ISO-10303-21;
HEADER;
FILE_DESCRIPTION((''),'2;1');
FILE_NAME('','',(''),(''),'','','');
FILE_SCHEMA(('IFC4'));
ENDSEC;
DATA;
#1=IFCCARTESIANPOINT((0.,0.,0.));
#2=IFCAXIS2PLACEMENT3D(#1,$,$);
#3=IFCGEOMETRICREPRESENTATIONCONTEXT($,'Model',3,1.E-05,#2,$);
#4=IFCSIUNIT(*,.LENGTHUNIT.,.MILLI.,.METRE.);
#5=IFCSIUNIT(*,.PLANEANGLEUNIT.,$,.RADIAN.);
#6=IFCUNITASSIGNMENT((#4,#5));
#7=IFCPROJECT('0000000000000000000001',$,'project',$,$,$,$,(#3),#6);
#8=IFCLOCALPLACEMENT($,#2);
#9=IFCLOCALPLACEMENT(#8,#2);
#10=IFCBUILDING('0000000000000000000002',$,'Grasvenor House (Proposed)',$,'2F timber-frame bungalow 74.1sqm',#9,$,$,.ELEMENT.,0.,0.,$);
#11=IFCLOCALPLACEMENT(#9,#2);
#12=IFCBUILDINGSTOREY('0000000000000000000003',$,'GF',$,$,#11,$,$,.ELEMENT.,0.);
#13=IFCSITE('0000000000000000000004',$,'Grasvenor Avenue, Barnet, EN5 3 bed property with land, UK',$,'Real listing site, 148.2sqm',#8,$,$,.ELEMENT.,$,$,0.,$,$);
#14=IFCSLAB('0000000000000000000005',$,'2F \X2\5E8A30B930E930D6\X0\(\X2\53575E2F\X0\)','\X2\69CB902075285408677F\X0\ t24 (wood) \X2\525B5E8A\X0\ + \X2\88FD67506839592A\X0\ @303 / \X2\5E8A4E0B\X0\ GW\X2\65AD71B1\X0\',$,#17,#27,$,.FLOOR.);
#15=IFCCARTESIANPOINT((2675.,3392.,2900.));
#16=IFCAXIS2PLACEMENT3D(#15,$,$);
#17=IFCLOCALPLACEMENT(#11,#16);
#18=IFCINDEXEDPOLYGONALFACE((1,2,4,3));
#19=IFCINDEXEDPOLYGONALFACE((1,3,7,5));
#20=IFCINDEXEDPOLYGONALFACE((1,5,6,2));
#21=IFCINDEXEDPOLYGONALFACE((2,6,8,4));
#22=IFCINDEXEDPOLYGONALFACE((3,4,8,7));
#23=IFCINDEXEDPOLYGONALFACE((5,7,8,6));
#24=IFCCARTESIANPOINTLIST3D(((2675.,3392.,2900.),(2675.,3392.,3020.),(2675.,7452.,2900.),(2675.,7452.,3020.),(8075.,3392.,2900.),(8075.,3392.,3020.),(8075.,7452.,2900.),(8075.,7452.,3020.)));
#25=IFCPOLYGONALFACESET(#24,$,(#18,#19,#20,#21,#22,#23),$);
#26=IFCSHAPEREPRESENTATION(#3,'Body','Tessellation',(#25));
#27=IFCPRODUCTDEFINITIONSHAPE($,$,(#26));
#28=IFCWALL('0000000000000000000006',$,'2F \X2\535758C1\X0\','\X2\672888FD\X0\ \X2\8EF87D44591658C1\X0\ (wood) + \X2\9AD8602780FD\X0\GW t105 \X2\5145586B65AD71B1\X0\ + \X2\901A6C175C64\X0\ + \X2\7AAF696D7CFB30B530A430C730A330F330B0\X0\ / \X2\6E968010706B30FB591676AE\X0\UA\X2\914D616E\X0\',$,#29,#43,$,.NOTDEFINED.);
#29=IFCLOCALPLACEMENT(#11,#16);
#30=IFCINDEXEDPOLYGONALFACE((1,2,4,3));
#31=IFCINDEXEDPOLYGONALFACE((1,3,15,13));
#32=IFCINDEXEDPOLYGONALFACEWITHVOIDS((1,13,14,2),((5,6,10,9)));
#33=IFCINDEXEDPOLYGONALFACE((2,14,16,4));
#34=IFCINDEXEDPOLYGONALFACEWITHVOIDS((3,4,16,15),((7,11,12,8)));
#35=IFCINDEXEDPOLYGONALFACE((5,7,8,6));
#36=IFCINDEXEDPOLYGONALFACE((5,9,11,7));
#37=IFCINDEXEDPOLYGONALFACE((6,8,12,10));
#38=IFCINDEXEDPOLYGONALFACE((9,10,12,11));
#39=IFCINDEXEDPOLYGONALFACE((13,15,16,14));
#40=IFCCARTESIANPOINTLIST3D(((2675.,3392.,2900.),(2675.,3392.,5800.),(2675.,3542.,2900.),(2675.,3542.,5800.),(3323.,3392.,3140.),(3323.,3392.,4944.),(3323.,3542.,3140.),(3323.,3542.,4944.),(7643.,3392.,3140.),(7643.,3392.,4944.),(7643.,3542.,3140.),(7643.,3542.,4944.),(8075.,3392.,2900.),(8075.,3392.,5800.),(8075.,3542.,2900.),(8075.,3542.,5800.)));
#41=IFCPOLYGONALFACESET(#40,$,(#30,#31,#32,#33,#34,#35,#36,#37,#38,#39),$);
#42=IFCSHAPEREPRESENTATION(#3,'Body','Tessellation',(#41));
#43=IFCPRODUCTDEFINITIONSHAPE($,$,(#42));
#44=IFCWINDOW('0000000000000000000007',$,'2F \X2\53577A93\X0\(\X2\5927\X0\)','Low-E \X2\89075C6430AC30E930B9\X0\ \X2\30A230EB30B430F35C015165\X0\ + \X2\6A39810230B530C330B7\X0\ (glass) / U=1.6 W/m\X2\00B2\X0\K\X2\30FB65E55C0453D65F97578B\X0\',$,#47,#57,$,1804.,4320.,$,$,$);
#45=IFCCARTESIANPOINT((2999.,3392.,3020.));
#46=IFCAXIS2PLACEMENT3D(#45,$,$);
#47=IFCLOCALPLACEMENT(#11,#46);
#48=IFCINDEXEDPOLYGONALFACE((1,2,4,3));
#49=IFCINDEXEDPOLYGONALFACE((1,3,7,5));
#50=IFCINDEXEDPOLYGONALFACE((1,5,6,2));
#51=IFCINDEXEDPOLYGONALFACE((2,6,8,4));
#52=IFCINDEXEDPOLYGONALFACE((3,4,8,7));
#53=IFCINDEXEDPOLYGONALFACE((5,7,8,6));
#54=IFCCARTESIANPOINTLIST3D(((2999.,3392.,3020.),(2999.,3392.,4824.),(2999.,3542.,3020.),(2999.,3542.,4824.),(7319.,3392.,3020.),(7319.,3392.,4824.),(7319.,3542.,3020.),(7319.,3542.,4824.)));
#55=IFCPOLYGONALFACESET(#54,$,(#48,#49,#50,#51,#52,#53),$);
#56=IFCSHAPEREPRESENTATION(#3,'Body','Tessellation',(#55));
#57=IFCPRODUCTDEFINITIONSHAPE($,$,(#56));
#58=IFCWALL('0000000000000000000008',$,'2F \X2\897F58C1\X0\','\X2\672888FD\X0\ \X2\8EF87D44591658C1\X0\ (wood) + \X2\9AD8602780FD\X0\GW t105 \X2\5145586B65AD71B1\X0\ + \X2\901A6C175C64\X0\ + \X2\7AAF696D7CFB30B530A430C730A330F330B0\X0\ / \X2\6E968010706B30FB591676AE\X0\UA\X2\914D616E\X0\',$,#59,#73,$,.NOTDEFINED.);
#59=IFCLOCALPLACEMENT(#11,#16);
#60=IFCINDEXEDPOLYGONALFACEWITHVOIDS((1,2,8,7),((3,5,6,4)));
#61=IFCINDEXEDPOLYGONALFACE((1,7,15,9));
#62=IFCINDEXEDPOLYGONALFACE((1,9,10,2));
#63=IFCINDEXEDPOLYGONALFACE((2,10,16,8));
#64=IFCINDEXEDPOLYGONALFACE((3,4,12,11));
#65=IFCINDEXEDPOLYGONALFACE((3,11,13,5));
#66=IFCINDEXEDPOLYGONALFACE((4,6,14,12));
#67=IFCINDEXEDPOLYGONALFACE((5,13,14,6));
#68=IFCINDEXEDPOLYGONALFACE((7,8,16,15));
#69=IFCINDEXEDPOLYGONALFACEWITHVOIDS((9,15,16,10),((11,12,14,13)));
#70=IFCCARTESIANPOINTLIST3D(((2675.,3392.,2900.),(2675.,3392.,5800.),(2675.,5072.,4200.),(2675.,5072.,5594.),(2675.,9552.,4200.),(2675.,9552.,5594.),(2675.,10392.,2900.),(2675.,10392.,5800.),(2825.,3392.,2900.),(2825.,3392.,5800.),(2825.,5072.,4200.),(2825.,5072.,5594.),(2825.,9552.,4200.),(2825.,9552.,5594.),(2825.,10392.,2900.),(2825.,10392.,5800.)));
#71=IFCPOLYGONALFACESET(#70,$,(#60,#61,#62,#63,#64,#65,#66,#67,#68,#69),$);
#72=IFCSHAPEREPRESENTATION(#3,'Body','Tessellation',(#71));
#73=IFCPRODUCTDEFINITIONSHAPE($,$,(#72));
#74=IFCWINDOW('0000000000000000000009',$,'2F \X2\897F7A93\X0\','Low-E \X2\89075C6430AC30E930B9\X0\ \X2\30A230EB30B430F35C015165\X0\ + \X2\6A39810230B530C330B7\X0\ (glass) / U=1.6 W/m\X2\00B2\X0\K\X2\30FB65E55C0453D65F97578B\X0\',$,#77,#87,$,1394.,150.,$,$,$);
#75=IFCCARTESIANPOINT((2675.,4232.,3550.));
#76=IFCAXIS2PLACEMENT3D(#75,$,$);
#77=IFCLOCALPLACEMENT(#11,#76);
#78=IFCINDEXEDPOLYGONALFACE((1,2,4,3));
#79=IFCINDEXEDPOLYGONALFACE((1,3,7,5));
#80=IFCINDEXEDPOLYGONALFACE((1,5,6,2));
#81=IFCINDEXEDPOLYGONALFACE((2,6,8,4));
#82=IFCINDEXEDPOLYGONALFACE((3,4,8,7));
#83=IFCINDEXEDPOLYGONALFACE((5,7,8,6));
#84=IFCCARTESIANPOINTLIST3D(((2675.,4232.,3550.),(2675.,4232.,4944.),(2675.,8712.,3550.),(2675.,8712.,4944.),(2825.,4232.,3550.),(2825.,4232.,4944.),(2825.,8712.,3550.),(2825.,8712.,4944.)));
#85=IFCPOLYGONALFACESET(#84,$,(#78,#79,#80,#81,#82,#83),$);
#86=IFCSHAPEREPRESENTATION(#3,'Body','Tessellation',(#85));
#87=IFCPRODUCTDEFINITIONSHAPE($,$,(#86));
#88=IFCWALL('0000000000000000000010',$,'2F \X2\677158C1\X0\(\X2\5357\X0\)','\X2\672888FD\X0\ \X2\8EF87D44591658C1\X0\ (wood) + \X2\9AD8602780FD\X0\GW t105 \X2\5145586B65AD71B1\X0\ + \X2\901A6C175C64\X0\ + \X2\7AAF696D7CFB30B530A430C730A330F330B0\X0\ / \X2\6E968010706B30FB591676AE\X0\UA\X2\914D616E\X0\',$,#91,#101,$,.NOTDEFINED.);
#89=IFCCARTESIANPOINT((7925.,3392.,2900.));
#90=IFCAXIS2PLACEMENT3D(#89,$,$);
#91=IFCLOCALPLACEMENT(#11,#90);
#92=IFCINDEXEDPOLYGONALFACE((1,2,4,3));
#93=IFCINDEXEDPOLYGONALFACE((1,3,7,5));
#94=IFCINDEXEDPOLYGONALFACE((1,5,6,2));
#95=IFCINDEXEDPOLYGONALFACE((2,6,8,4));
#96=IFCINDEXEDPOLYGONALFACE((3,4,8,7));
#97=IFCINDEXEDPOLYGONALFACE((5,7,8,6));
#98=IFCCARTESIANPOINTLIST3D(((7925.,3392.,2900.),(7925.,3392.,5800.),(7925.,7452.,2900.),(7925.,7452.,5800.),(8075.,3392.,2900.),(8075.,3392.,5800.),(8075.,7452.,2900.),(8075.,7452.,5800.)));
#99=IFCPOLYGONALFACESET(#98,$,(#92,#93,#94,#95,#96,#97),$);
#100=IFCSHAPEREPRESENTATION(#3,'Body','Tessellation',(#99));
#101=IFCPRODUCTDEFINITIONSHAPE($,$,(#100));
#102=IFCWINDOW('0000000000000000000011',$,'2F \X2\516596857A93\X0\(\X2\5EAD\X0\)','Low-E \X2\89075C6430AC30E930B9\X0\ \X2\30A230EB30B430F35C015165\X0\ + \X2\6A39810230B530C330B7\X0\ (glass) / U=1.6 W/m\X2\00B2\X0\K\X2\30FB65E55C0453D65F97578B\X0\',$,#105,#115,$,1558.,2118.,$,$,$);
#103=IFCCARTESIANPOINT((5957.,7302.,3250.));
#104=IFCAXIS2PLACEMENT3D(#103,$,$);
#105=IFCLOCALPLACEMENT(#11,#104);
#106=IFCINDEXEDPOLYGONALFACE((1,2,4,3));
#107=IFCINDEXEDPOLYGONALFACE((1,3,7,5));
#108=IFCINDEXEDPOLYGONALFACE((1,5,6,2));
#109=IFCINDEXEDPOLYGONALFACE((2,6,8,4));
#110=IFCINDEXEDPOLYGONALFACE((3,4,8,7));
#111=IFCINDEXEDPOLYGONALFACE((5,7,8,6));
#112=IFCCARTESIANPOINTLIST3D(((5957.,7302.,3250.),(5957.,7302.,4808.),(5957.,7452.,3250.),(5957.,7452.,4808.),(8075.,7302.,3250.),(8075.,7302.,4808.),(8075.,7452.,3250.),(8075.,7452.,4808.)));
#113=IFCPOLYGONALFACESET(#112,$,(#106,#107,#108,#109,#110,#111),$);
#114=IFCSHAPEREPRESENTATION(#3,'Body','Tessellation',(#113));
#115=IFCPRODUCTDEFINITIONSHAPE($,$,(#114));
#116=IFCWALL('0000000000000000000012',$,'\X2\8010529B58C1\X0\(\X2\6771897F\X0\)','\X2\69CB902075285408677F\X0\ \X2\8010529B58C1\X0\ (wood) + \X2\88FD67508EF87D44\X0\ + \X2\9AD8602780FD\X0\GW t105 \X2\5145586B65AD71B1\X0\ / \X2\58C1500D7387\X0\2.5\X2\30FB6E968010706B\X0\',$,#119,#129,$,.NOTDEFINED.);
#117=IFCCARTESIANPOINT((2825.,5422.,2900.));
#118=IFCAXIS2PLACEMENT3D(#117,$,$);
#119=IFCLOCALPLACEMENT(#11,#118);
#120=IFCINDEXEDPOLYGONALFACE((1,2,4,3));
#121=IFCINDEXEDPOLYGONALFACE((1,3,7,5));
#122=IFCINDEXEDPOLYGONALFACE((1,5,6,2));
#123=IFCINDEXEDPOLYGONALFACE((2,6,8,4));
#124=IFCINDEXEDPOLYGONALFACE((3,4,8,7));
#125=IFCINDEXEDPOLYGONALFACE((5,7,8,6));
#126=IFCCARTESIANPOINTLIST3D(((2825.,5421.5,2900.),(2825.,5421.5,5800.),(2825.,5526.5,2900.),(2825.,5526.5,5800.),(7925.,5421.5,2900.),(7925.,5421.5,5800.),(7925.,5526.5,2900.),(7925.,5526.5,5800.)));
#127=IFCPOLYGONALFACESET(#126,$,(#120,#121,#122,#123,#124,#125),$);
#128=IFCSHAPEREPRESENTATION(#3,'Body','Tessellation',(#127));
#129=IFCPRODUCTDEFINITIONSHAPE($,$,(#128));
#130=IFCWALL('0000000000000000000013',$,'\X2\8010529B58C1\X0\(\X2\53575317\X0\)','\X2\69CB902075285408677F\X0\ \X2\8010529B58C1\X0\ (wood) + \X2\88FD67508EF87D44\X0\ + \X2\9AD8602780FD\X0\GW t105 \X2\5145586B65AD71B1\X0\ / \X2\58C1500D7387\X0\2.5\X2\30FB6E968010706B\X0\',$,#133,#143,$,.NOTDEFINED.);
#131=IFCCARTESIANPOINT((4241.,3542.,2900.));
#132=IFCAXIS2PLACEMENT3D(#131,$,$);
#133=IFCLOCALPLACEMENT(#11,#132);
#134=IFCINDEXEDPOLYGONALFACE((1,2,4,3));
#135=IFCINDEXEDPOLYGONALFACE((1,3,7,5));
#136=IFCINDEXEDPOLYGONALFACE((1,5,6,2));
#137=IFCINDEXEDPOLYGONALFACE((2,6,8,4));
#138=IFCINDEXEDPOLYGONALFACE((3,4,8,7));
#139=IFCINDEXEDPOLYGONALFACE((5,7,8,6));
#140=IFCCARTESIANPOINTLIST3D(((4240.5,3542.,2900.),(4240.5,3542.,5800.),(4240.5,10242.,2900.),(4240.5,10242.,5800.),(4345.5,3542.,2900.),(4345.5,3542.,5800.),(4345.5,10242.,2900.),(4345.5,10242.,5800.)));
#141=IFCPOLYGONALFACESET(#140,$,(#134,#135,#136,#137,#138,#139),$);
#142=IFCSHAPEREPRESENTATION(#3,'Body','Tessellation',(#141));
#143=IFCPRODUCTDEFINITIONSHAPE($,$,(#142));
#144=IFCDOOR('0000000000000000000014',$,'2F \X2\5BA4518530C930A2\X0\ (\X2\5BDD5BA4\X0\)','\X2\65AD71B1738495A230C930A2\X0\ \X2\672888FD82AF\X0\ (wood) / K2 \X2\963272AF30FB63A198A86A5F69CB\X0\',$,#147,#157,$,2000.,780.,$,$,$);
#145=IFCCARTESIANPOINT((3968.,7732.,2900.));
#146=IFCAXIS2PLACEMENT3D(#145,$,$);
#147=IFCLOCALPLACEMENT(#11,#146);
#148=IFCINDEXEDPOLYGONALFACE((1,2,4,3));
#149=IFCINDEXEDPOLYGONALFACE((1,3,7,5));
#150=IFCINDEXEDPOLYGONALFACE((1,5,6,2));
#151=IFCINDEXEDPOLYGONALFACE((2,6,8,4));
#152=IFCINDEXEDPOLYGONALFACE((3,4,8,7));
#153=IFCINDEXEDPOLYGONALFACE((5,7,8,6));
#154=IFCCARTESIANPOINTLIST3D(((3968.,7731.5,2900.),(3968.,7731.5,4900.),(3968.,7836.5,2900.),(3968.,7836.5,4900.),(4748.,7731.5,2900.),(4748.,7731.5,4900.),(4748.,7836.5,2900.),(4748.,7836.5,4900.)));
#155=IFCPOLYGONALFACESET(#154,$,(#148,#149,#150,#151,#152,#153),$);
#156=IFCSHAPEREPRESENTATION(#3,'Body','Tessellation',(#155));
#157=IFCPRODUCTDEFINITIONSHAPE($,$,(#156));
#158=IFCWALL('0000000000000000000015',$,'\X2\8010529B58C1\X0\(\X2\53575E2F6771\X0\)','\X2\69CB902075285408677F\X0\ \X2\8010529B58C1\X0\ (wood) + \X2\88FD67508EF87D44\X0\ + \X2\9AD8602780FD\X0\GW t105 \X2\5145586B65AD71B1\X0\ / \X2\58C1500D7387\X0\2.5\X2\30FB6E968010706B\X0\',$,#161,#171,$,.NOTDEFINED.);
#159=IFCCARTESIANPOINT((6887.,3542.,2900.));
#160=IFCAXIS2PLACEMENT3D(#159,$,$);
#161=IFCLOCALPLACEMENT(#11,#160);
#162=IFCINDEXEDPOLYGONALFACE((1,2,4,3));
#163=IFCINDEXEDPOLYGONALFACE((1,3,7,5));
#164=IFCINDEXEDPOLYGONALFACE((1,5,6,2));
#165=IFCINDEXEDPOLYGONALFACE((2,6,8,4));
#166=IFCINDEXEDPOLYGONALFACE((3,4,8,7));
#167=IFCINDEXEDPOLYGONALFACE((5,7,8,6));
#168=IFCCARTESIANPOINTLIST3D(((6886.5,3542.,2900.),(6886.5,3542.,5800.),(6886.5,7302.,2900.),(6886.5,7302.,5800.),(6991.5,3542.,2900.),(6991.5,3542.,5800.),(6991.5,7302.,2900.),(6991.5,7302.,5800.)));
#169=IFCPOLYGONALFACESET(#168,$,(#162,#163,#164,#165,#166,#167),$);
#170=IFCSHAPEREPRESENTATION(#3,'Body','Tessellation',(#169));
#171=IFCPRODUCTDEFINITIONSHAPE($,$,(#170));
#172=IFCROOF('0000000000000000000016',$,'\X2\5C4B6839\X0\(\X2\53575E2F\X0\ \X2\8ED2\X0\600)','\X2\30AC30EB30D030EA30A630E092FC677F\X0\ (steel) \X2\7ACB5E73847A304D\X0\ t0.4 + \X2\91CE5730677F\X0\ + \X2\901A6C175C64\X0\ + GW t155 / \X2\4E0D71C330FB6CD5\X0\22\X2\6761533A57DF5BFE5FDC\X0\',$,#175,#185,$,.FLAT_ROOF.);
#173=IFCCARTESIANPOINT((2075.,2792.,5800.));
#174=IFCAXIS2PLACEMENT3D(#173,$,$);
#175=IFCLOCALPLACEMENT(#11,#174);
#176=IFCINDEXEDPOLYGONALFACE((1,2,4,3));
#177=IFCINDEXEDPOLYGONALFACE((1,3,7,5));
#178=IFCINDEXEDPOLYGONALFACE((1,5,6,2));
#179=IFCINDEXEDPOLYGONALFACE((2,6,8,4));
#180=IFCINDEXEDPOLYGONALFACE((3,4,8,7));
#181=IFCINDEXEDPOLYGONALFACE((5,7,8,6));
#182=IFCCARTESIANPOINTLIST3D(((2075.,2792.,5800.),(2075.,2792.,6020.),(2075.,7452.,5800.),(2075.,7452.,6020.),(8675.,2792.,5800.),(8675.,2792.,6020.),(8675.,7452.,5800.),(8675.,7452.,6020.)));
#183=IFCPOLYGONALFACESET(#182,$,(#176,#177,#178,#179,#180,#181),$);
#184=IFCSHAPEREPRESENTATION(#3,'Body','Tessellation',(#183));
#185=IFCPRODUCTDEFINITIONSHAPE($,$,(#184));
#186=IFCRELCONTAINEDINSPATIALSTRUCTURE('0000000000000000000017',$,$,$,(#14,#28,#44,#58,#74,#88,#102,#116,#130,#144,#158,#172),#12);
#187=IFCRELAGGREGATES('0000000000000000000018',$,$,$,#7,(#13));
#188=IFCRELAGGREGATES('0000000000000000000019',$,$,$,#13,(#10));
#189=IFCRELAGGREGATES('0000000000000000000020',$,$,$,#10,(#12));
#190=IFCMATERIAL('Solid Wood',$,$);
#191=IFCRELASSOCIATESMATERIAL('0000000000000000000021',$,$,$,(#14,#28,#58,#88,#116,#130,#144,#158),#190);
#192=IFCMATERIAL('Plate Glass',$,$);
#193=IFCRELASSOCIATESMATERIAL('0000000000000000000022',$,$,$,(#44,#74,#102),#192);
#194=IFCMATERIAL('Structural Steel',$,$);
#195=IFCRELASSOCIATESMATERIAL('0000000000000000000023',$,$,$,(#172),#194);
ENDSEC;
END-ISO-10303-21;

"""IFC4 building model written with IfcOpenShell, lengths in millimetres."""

from ifc_helpers import new_model, si_unit, frame, frame_2d, origin, place, context, project, spatial, rectangle, extrude, material, element, fill, save


model = new_model("IFC4")

# Units and contexts
model_context = context("Model", 3, precision=1e-05, world=origin())
ifc_project = project(units=[si_unit("LENGTHUNIT", "METRE", prefix="MILLI"), si_unit("PLANEANGLEUNIT", "RADIAN")], contexts=[model_context])

# Site, building, storey
site_placement = place(None, origin())
site = spatial("IfcSite", under=ifc_project, at=site_placement, Name="Grasvenor Avenue, Barnet, EN5 3 bed property with land, UK", ObjectType="Real listing site, 148.2sqm", CompositionType="ELEMENT", RefElevation=0.0)
building_placement = place(site_placement, origin())
building = spatial("IfcBuilding", under=site, at=building_placement, Name="Grasvenor House (Proposed)", ObjectType="2F timber-frame bungalow 74.1sqm", CompositionType="ELEMENT", ElevationOfRefHeight=0.0, ElevationOfTerrain=0.0)
storey_placement = place(building_placement, origin())
storey = spatial("IfcBuildingStorey", under=building, at=storey_placement, Name="GF", CompositionType="ELEMENT", Elevation=0.0)

# Slab
ifc_material_1 = material(Name="Solid Wood")
slab_placement = place(storey_placement, frame((2675.0, 3392.0, 2900.0)))
element("IfcSlab", 1, at=slab_placement, inside=storey, material=ifc_material_1, Name="2F 床スラブ(南帯)", Description="構造用合板 t24 (wood) 剛床 + 製材根太 @303 / 床下 GW断熱", PredefinedType="FLOOR", context=model_context, shape_type="SweptSolid", body=[
    extrude(rectangle(XDim=5400.0, YDim=4060.0, at=frame_2d((2700.0, 2030.0))), frame((2675.0, 3392.0, 2900.0)), (0.0, 0.0, 1.0), 120.0),
])

# Walls, openings, windows
wall_1_placement = place(storey_placement, frame((2675.0, 3392.0, 2900.0)))
wall_1 = element("IfcWall", 2, at=wall_1_placement, inside=storey, material=ifc_material_1, Name="2F 南壁", Description="木製 軸組外壁 (wood) + 高性能GW t105 充填断熱 + 通気層 + 窯業系サイディング / 準耐火・外皮UA配慮", PredefinedType="NOTDEFINED", context=model_context, shape_type="SweptSolid", body=[
    extrude(rectangle(XDim=5400.0, YDim=150.0, at=frame_2d((2700.0, 75.0))), frame((2675.0, 3392.0, 2900.0)), (0.0, 0.0, 1.0), 2900.0),
])
opening_1_placement = place(storey_placement, frame((2999.0, 3392.0, 3020.0)))
opening_1 = element("IfcOpeningElement", 3, at=opening_1_placement, cuts=wall_1, PredefinedType="NOTDEFINED", context=model_context, shape_type="SweptSolid", body=[
    extrude(rectangle(XDim=4320.0, YDim=150.0, at=frame_2d((2160.0, 75.0))), frame((2999.0, 3392.0, 3020.0)), (0.0, 0.0, 1.0), 1804.0),
])
ifc_material_2 = material(Name="Plate Glass")
window_1_placement = place(storey_placement, frame((2999.0, 3392.0, 3020.0)))
window_1 = element("IfcWindow", 4, at=window_1_placement, inside=storey, material=ifc_material_2, Name="2F 南窓(大)", Description="Low-E 複層ガラス アルゴン封入 + 樹脂サッシ (glass) / U=1.6 W/m²K・日射取得型", OverallHeight=1804.0, OverallWidth=4320.0, context=model_context, shape_type="SweptSolid", body=[
    extrude(rectangle(XDim=4320.0, YDim=150.0, at=frame_2d((2160.0, 75.0))), frame((2999.0, 3392.0, 3020.0)), (0.0, 0.0, 1.0), 1804.0),
])
fill(opening_1, window_1)
wall_2_placement = place(storey_placement, frame((2675.0, 3392.0, 2900.0)))
wall_2 = element("IfcWall", 5, at=wall_2_placement, inside=storey, material=ifc_material_1, Name="2F 西壁", Description="木製 軸組外壁 (wood) + 高性能GW t105 充填断熱 + 通気層 + 窯業系サイディング / 準耐火・外皮UA配慮", PredefinedType="NOTDEFINED", context=model_context, shape_type="SweptSolid", body=[
    extrude(rectangle(XDim=150.0, YDim=7000.0, at=frame_2d((75.0, 3500.0))), frame((2675.0, 3392.0, 2900.0)), (0.0, 0.0, 1.0), 2900.0),
])
opening_2_placement = place(storey_placement, frame((2675.0, 4232.0, 3550.0)))
opening_2 = element("IfcOpeningElement", 6, at=opening_2_placement, cuts=wall_2, PredefinedType="NOTDEFINED", context=model_context, shape_type="SweptSolid", body=[
    extrude(rectangle(XDim=150.0, YDim=4480.0, at=frame_2d((75.0, 2240.0))), frame((2675.0, 4232.0, 3550.0)), (0.0, 0.0, 1.0), 1394.0),
])
window_2_placement = place(storey_placement, frame((2675.0, 4232.0, 3550.0)))
window_2 = element("IfcWindow", 7, at=window_2_placement, inside=storey, material=ifc_material_2, Name="2F 西窓", Description="Low-E 複層ガラス アルゴン封入 + 樹脂サッシ (glass) / U=1.6 W/m²K・日射取得型", OverallHeight=1394.0, OverallWidth=150.0, context=model_context, shape_type="SweptSolid", body=[
    extrude(rectangle(XDim=150.0, YDim=4480.0, at=frame_2d((75.0, 2240.0))), frame((2675.0, 4232.0, 3550.0)), (0.0, 0.0, 1.0), 1394.0),
])
fill(opening_2, window_2)
wall_3_placement = place(storey_placement, frame((7925.0, 3392.0, 2900.0)))
wall_3 = element("IfcWall", 8, at=wall_3_placement, inside=storey, material=ifc_material_1, Name="2F 東壁(南)", Description="木製 軸組外壁 (wood) + 高性能GW t105 充填断熱 + 通気層 + 窯業系サイディング / 準耐火・外皮UA配慮", PredefinedType="NOTDEFINED", context=model_context, shape_type="SweptSolid", body=[
    extrude(rectangle(XDim=150.0, YDim=4060.0, at=frame_2d((75.0, 2030.0))), frame((7925.0, 3392.0, 2900.0)), (0.0, 0.0, 1.0), 2900.0),
])
opening_3_placement = place(storey_placement, frame((5957.0, 7302.0, 3250.0)))
opening_3 = element("IfcOpeningElement", 9, at=opening_3_placement, cuts=wall_3, PredefinedType="NOTDEFINED", context=model_context, shape_type="SweptSolid", body=[
    extrude(rectangle(XDim=2118.0, YDim=150.0, at=frame_2d((1059.0, 75.0))), frame((5957.0, 7302.0, 3250.0)), (0.0, 0.0, 1.0), 1558.0),
])
window_3_placement = place(storey_placement, frame((5957.0, 7302.0, 3250.0)))
window_3 = element("IfcWindow", 10, at=window_3_placement, inside=storey, material=ifc_material_2, Name="2F 入隅窓(庭)", Description="Low-E 複層ガラス アルゴン封入 + 樹脂サッシ (glass) / U=1.6 W/m²K・日射取得型", OverallHeight=1558.0, OverallWidth=2118.0, context=model_context, shape_type="SweptSolid", body=[
    extrude(rectangle(XDim=2118.0, YDim=150.0, at=frame_2d((1059.0, 75.0))), frame((5957.0, 7302.0, 3250.0)), (0.0, 0.0, 1.0), 1558.0),
])
fill(opening_3, window_3)

# Wall
wall_4_placement = place(storey_placement, frame((2825.0, 5422.0, 2900.0)))
element("IfcWall", 11, at=wall_4_placement, inside=storey, material=ifc_material_1, Name="耐力壁(東西)", Description="構造用合板 耐力壁 (wood) + 製材軸組 + 高性能GW t105 充填断熱 / 壁倍率2.5・準耐火", PredefinedType="NOTDEFINED", context=model_context, shape_type="SweptSolid", body=[
    extrude(rectangle(XDim=5100.0, YDim=105.0, at=frame_2d((2550.0, 52.0))), frame((2825.0, 5422.0, 2900.0)), (0.0, 0.0, 1.0), 2900.0),
])

# Wall, opening, door
wall_5_placement = place(storey_placement, frame((4241.0, 3542.0, 2900.0)))
wall_5 = element("IfcWall", 12, at=wall_5_placement, inside=storey, material=ifc_material_1, Name="耐力壁(南北)", Description="構造用合板 耐力壁 (wood) + 製材軸組 + 高性能GW t105 充填断熱 / 壁倍率2.5・準耐火", PredefinedType="NOTDEFINED", context=model_context, shape_type="SweptSolid", body=[
    extrude(rectangle(XDim=105.0, YDim=6700.0, at=frame_2d((52.0, 3350.0))), frame((4241.0, 3542.0, 2900.0)), (0.0, 0.0, 1.0), 2900.0),
])
opening_4_placement = place(storey_placement, frame((3968.0, 7732.0, 2900.0)))
opening_4 = element("IfcOpeningElement", 13, at=opening_4_placement, cuts=wall_5, PredefinedType="NOTDEFINED", context=model_context, shape_type="SweptSolid", body=[
    extrude(rectangle(XDim=780.0, YDim=105.0, at=frame_2d((390.0, 52.0))), frame((3968.0, 7732.0, 2900.0)), (0.0, 0.0, 1.0), 2000.0),
])
door_placement = place(storey_placement, frame((3968.0, 7732.0, 2900.0)))
door = element("IfcDoor", 14, at=door_placement, inside=storey, material=ifc_material_1, Name="2F 室内ドア (寝室)", Description="断熱玄関ドア 木製芯 (wood) / K2 防犯・採風機構", OverallHeight=2000.0, OverallWidth=780.0, context=model_context, shape_type="SweptSolid", body=[
    extrude(rectangle(XDim=780.0, YDim=105.0, at=frame_2d((390.0, 52.0))), frame((3968.0, 7732.0, 2900.0)), (0.0, 0.0, 1.0), 2000.0),
])
fill(opening_4, door)

# Wall
wall_6_placement = place(storey_placement, frame((6887.0, 3542.0, 2900.0)))
element("IfcWall", 15, at=wall_6_placement, inside=storey, material=ifc_material_1, Name="耐力壁(南帯東)", Description="構造用合板 耐力壁 (wood) + 製材軸組 + 高性能GW t105 充填断熱 / 壁倍率2.5・準耐火", PredefinedType="NOTDEFINED", context=model_context, shape_type="SweptSolid", body=[
    extrude(rectangle(XDim=105.0, YDim=3760.0, at=frame_2d((52.0, 1880.0))), frame((6887.0, 3542.0, 2900.0)), (0.0, 0.0, 1.0), 2900.0),
])

# Roof
ifc_material_3 = material(Name="Structural Steel")
for number, where, name in (
    (16, (2075.0, 2792.0, 5800.0), "屋根(南帯 軒600)"),
):
    element("IfcRoof", number, at=place(storey_placement, frame(where)), inside=storey, material=ifc_material_3, Name=name, Description="ガルバリウム鋼板 (steel) 立平葺き t0.4 + 野地板 + 通気層 + GW t155 / 不燃・法22条区域対応", PredefinedType="FLAT_ROOF", context=model_context, shape_type="SweptSolid", body=[
        extrude(rectangle(XDim=6600.0, YDim=4660.0, at=frame_2d((3300.0, 2330.0))), frame((2075.0, 2792.0, 5800.0)), (0.0, 0.0, 1.0), 220.0),
    ])

save(model, "model.ifc")
